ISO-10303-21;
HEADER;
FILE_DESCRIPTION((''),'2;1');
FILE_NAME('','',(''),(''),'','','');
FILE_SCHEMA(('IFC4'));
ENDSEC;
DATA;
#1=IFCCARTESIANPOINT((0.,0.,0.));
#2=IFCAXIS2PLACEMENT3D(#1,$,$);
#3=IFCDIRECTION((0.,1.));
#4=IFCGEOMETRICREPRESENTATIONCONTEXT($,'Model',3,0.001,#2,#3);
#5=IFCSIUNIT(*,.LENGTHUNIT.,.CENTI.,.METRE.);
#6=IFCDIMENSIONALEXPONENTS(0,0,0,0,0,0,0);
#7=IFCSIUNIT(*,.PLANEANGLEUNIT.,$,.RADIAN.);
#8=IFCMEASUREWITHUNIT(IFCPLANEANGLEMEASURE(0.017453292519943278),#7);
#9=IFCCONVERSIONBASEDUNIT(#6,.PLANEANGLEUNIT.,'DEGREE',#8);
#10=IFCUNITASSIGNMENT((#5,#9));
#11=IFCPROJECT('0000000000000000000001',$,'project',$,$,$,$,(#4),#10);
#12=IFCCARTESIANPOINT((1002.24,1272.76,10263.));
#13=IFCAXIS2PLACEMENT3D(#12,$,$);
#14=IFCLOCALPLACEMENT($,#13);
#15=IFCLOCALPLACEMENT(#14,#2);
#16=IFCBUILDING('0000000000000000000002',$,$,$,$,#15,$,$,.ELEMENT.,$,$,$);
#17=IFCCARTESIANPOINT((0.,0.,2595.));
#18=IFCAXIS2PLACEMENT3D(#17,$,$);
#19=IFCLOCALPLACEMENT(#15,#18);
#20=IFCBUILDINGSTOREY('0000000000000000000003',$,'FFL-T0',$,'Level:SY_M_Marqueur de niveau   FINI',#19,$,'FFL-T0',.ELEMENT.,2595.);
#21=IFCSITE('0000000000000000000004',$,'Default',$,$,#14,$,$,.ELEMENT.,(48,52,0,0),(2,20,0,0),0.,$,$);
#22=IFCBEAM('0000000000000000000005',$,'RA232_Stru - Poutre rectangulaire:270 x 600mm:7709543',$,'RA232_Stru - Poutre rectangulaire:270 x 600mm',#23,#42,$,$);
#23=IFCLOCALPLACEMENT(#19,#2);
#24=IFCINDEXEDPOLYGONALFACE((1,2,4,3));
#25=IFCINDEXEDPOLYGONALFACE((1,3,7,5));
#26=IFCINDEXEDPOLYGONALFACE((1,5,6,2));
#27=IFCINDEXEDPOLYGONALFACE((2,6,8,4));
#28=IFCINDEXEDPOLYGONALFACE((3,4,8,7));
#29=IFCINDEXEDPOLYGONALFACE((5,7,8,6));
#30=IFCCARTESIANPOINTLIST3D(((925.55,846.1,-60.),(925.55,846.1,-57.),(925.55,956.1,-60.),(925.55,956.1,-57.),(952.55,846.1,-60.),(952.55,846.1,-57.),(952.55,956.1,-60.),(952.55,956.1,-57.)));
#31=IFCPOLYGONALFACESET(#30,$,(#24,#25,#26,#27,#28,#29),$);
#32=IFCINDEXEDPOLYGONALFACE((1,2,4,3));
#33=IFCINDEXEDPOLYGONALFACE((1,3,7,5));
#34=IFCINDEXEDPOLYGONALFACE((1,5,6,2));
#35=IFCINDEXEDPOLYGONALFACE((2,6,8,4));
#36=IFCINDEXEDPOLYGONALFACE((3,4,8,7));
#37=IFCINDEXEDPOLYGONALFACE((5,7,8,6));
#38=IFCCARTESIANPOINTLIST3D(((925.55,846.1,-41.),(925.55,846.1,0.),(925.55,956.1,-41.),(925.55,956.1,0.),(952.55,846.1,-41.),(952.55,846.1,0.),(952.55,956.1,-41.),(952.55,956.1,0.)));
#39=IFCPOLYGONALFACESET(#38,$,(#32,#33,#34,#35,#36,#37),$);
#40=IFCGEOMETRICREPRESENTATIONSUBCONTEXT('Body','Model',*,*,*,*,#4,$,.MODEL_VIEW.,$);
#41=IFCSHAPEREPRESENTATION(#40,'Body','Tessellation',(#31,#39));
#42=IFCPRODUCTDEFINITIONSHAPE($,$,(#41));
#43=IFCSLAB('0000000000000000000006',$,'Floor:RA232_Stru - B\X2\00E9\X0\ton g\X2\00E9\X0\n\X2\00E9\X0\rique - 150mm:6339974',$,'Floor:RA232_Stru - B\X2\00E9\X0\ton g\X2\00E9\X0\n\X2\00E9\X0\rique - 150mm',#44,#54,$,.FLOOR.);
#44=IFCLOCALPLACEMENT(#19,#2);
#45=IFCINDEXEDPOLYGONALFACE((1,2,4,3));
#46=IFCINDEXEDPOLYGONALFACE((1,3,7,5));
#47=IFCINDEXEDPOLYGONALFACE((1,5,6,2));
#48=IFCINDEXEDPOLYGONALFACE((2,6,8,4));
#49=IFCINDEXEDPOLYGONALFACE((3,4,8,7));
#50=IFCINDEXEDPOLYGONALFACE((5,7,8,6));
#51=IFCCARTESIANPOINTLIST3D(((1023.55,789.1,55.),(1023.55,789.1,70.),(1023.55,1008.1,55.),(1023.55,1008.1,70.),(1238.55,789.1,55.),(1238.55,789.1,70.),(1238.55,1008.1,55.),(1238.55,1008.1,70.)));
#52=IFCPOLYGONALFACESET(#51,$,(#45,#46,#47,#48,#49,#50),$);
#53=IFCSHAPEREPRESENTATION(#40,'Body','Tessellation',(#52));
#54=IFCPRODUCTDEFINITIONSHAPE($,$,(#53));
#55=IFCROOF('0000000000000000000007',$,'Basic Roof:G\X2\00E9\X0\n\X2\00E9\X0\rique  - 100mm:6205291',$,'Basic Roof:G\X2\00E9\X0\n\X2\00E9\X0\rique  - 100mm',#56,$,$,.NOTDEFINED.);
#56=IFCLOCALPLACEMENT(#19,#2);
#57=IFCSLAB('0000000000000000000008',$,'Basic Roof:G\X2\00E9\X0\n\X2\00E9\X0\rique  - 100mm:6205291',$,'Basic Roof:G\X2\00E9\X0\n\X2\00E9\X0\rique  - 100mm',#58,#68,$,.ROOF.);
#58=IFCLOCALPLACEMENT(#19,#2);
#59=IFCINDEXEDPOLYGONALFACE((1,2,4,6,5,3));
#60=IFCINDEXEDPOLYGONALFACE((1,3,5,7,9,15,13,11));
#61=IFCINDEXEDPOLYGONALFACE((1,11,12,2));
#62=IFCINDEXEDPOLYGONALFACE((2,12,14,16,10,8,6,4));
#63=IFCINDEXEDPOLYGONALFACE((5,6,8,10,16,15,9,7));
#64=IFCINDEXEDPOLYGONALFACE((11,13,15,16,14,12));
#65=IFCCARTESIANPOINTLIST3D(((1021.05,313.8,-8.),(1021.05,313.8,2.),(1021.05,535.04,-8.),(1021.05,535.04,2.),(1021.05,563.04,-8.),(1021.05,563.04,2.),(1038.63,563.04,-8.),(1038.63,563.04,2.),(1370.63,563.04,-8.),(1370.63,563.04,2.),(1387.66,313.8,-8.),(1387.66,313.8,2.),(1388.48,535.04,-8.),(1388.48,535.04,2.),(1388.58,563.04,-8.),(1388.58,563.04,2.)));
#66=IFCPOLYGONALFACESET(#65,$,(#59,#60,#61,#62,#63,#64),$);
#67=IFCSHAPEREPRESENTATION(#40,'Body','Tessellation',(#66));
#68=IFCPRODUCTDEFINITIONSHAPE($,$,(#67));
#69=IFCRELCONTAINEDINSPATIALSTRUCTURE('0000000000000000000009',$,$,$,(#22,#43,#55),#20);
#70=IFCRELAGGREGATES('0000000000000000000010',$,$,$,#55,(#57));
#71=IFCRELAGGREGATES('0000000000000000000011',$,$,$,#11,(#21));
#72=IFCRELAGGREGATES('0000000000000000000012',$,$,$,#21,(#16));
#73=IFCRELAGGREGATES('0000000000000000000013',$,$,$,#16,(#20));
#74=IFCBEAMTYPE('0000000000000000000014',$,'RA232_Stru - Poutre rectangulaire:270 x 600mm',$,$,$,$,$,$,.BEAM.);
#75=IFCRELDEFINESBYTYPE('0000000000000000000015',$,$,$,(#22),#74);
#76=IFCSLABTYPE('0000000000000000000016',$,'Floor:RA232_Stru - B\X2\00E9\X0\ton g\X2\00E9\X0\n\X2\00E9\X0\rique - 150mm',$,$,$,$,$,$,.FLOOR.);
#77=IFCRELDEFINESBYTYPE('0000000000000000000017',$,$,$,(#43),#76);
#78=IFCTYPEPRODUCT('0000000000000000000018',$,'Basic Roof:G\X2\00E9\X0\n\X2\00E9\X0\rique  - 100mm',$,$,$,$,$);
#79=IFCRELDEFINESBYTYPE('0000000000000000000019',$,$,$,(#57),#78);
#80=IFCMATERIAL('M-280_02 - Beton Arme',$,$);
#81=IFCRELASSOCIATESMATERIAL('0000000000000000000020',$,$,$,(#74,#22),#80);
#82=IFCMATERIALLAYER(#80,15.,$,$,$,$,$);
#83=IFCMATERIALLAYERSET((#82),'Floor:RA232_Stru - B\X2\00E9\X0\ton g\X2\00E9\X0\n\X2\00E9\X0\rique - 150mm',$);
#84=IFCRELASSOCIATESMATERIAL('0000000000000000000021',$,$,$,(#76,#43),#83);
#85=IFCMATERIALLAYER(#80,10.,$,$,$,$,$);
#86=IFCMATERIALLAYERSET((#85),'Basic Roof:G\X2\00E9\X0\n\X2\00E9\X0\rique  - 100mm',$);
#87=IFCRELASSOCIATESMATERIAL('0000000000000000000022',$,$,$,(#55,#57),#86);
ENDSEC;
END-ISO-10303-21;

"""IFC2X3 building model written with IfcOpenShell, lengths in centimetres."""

from ifc_helpers import new_model, entity, si_unit, converted_unit, direction, frame, frame_2d, origin, place, context, subcontext, project, spatial, polyline, rectangle, outline, extrude, source, transform, mapped, material, layer, layer_set, layer_usage, type_object, type_shapes, element, aggregate, save


model = new_model("IFC2X3")

# Units and contexts
model_context = context("Model", 3, precision=0.001, world=origin(), true_north=direction((0.0, 1.0)))
body_context = subcontext(model_context, "Body", "Model", "MODEL_VIEW")
ifc_project = project(units=[si_unit("LENGTHUNIT", "METRE", prefix="CENTI"), converted_unit("PLANEANGLEUNIT", "DEGREE", entity("IfcPlaneAngleMeasure", 0.017453292519943278), si_unit("PLANEANGLEUNIT", "RADIAN"), dimensions=[0, 0, 0, 0, 0, 0, 0])], contexts=[model_context])

# Site, building, storey
site_placement = place(None, frame((1002.24, 1272.76, 10263.0)))
site = spatial("IfcSite", under=ifc_project, at=site_placement, Name="Default", CompositionType="ELEMENT", RefLatitude=(48, 52, 0, 0), RefLongitude=(2, 20, 0, 0), RefElevation=0.0)
building_placement = place(site_placement, origin())
building = spatial("IfcBuilding", under=site, at=building_placement, CompositionType="ELEMENT")
storey_placement = place(building_placement, frame((0.0, 0.0, 2595.0)))
storey = spatial("IfcBuildingStorey", under=building, at=storey_placement, Name="FFL-T0", ObjectType="Level:SY_M_Marqueur de niveau   FINI", LongName="FFL-T0", CompositionType="ELEMENT", Elevation=2595.0)

# Beam
ifc_material_1 = material(Name="M-280_02 - Beton Arme")
beam_type_1 = type_object("IfcBeamType", Name="RA232_Stru - Poutre rectangulaire:270 x 600mm", PredefinedType="BEAM", material=ifc_material_1)
shared_shape_1 = source(origin(), body_context, "Body", "SweptSolid", [
    extrude(rectangle(XDim=3.0, YDim=27.0, at=frame_2d((0.0, 0.0), x_axis=(0.0, 1.0))), frame((939.05, 956.1, 2536.5), z_axis=(0.0, -1.0, 0.0), x_axis=(-1.0, 0.0, 0.0)), (0.0, 0.0, 1.0), 110.0),
    extrude(rectangle(XDim=41.0, YDim=27.0, at=frame_2d((0.0, 0.0), x_axis=(0.0, 1.0))), frame((939.05, 956.1, 2574.5), z_axis=(0.0, -1.0, 0.0), x_axis=(-1.0, 0.0, 0.0)), (0.0, 0.0, 1.0), 110.0),
])
type_shapes(beam_type_1, [shared_shape_1])
beam_1_placement = place(storey_placement, frame((0.0, 0.0, -2595.0)))
element("IfcBeam", 1, at=beam_1_placement, inside=storey, type_object=beam_type_1, material=ifc_material_1, Name="RA232_Stru - Poutre rectangulaire:270 x 600mm:7709543", ObjectType="RA232_Stru - Poutre rectangulaire:270 x 600mm", context=body_context, shape_type="MappedRepresentation", body=[
    mapped(shared_shape_1, transform((0.0, 0.0, 0.0), scale=1.0)),
])

# Slab
ifc_layer_1 = layer(ifc_material_1, 15.0)
ifc_layer_set_1 = layer_set([ifc_layer_1], Name="Floor:RA232_Stru - Béton générique - 150mm")
ifc_layer_usage_1 = layer_usage(ifc_layer_set_1, "AXIS3", "POSITIVE", 0.0)
slab_type_1 = type_object("IfcSlabType", Name="Floor:RA232_Stru - Béton générique - 150mm", PredefinedType="FLOOR", material=ifc_layer_set_1)
slab_1_placement = place(storey_placement, origin())
element("IfcSlab", 2, at=slab_1_placement, inside=storey, type_object=slab_type_1, material=ifc_layer_usage_1, Name="Floor:RA232_Stru - Béton générique - 150mm:6339974", ObjectType="Floor:RA232_Stru - Béton générique - 150mm", PredefinedType="FLOOR", context=body_context, shape_type="SweptSolid", body=[
    extrude(rectangle(XDim=219.0, YDim=215.0, at=frame_2d((0.0, 0.0), x_axis=(1.0, 0.0))), frame((1131.05, 898.6, 70.0), z_axis=(0.0, 0.0, -1.0), x_axis=(0.0, 1.0, 0.0)), (0.0, 0.0, 1.0), 15.0),
])

# Roof, slab
ifc_layer_2 = layer(ifc_material_1, 10.0)
ifc_layer_set_2 = layer_set([ifc_layer_2], Name="Basic Roof:Générique  - 100mm")
roof_placement = place(storey_placement, frame((1021.05, 313.8, -8.0)))
roof = element("IfcRoof", 3, at=roof_placement, inside=storey, material=ifc_layer_set_2, Name="Basic Roof:Générique  - 100mm:6205291", ObjectType="Basic Roof:Générique  - 100mm", ShapeType="NOTDEFINED")
type_product = type_object("IfcTypeProduct", Name="Basic Roof:Générique  - 100mm")
slab_2_placement = place(roof_placement, origin())
slab_2 = element("IfcSlab", 4, at=slab_2_placement, type_object=type_product, material=ifc_layer_set_2, Name="Basic Roof:Générique  - 100mm:6205291", ObjectType="Basic Roof:Générique  - 100mm", PredefinedType="ROOF", context=body_context, shape_type="SweptSolid", body=[
    extrude(outline(polyline([(-183.77, -124.62), (182.85, -124.62), (183.66, 96.62), (183.77, 124.62), (165.82, 124.62), (-166.18, 124.62), (-183.77, 124.62), (-183.77, 96.62), (-183.77, -124.62)])), frame((183.77, 124.62, 0.0)), (0.0, 0.0, 1.0), 10.0),
])
aggregate(roof, [slab_2])

save(model, "model.ifc")
